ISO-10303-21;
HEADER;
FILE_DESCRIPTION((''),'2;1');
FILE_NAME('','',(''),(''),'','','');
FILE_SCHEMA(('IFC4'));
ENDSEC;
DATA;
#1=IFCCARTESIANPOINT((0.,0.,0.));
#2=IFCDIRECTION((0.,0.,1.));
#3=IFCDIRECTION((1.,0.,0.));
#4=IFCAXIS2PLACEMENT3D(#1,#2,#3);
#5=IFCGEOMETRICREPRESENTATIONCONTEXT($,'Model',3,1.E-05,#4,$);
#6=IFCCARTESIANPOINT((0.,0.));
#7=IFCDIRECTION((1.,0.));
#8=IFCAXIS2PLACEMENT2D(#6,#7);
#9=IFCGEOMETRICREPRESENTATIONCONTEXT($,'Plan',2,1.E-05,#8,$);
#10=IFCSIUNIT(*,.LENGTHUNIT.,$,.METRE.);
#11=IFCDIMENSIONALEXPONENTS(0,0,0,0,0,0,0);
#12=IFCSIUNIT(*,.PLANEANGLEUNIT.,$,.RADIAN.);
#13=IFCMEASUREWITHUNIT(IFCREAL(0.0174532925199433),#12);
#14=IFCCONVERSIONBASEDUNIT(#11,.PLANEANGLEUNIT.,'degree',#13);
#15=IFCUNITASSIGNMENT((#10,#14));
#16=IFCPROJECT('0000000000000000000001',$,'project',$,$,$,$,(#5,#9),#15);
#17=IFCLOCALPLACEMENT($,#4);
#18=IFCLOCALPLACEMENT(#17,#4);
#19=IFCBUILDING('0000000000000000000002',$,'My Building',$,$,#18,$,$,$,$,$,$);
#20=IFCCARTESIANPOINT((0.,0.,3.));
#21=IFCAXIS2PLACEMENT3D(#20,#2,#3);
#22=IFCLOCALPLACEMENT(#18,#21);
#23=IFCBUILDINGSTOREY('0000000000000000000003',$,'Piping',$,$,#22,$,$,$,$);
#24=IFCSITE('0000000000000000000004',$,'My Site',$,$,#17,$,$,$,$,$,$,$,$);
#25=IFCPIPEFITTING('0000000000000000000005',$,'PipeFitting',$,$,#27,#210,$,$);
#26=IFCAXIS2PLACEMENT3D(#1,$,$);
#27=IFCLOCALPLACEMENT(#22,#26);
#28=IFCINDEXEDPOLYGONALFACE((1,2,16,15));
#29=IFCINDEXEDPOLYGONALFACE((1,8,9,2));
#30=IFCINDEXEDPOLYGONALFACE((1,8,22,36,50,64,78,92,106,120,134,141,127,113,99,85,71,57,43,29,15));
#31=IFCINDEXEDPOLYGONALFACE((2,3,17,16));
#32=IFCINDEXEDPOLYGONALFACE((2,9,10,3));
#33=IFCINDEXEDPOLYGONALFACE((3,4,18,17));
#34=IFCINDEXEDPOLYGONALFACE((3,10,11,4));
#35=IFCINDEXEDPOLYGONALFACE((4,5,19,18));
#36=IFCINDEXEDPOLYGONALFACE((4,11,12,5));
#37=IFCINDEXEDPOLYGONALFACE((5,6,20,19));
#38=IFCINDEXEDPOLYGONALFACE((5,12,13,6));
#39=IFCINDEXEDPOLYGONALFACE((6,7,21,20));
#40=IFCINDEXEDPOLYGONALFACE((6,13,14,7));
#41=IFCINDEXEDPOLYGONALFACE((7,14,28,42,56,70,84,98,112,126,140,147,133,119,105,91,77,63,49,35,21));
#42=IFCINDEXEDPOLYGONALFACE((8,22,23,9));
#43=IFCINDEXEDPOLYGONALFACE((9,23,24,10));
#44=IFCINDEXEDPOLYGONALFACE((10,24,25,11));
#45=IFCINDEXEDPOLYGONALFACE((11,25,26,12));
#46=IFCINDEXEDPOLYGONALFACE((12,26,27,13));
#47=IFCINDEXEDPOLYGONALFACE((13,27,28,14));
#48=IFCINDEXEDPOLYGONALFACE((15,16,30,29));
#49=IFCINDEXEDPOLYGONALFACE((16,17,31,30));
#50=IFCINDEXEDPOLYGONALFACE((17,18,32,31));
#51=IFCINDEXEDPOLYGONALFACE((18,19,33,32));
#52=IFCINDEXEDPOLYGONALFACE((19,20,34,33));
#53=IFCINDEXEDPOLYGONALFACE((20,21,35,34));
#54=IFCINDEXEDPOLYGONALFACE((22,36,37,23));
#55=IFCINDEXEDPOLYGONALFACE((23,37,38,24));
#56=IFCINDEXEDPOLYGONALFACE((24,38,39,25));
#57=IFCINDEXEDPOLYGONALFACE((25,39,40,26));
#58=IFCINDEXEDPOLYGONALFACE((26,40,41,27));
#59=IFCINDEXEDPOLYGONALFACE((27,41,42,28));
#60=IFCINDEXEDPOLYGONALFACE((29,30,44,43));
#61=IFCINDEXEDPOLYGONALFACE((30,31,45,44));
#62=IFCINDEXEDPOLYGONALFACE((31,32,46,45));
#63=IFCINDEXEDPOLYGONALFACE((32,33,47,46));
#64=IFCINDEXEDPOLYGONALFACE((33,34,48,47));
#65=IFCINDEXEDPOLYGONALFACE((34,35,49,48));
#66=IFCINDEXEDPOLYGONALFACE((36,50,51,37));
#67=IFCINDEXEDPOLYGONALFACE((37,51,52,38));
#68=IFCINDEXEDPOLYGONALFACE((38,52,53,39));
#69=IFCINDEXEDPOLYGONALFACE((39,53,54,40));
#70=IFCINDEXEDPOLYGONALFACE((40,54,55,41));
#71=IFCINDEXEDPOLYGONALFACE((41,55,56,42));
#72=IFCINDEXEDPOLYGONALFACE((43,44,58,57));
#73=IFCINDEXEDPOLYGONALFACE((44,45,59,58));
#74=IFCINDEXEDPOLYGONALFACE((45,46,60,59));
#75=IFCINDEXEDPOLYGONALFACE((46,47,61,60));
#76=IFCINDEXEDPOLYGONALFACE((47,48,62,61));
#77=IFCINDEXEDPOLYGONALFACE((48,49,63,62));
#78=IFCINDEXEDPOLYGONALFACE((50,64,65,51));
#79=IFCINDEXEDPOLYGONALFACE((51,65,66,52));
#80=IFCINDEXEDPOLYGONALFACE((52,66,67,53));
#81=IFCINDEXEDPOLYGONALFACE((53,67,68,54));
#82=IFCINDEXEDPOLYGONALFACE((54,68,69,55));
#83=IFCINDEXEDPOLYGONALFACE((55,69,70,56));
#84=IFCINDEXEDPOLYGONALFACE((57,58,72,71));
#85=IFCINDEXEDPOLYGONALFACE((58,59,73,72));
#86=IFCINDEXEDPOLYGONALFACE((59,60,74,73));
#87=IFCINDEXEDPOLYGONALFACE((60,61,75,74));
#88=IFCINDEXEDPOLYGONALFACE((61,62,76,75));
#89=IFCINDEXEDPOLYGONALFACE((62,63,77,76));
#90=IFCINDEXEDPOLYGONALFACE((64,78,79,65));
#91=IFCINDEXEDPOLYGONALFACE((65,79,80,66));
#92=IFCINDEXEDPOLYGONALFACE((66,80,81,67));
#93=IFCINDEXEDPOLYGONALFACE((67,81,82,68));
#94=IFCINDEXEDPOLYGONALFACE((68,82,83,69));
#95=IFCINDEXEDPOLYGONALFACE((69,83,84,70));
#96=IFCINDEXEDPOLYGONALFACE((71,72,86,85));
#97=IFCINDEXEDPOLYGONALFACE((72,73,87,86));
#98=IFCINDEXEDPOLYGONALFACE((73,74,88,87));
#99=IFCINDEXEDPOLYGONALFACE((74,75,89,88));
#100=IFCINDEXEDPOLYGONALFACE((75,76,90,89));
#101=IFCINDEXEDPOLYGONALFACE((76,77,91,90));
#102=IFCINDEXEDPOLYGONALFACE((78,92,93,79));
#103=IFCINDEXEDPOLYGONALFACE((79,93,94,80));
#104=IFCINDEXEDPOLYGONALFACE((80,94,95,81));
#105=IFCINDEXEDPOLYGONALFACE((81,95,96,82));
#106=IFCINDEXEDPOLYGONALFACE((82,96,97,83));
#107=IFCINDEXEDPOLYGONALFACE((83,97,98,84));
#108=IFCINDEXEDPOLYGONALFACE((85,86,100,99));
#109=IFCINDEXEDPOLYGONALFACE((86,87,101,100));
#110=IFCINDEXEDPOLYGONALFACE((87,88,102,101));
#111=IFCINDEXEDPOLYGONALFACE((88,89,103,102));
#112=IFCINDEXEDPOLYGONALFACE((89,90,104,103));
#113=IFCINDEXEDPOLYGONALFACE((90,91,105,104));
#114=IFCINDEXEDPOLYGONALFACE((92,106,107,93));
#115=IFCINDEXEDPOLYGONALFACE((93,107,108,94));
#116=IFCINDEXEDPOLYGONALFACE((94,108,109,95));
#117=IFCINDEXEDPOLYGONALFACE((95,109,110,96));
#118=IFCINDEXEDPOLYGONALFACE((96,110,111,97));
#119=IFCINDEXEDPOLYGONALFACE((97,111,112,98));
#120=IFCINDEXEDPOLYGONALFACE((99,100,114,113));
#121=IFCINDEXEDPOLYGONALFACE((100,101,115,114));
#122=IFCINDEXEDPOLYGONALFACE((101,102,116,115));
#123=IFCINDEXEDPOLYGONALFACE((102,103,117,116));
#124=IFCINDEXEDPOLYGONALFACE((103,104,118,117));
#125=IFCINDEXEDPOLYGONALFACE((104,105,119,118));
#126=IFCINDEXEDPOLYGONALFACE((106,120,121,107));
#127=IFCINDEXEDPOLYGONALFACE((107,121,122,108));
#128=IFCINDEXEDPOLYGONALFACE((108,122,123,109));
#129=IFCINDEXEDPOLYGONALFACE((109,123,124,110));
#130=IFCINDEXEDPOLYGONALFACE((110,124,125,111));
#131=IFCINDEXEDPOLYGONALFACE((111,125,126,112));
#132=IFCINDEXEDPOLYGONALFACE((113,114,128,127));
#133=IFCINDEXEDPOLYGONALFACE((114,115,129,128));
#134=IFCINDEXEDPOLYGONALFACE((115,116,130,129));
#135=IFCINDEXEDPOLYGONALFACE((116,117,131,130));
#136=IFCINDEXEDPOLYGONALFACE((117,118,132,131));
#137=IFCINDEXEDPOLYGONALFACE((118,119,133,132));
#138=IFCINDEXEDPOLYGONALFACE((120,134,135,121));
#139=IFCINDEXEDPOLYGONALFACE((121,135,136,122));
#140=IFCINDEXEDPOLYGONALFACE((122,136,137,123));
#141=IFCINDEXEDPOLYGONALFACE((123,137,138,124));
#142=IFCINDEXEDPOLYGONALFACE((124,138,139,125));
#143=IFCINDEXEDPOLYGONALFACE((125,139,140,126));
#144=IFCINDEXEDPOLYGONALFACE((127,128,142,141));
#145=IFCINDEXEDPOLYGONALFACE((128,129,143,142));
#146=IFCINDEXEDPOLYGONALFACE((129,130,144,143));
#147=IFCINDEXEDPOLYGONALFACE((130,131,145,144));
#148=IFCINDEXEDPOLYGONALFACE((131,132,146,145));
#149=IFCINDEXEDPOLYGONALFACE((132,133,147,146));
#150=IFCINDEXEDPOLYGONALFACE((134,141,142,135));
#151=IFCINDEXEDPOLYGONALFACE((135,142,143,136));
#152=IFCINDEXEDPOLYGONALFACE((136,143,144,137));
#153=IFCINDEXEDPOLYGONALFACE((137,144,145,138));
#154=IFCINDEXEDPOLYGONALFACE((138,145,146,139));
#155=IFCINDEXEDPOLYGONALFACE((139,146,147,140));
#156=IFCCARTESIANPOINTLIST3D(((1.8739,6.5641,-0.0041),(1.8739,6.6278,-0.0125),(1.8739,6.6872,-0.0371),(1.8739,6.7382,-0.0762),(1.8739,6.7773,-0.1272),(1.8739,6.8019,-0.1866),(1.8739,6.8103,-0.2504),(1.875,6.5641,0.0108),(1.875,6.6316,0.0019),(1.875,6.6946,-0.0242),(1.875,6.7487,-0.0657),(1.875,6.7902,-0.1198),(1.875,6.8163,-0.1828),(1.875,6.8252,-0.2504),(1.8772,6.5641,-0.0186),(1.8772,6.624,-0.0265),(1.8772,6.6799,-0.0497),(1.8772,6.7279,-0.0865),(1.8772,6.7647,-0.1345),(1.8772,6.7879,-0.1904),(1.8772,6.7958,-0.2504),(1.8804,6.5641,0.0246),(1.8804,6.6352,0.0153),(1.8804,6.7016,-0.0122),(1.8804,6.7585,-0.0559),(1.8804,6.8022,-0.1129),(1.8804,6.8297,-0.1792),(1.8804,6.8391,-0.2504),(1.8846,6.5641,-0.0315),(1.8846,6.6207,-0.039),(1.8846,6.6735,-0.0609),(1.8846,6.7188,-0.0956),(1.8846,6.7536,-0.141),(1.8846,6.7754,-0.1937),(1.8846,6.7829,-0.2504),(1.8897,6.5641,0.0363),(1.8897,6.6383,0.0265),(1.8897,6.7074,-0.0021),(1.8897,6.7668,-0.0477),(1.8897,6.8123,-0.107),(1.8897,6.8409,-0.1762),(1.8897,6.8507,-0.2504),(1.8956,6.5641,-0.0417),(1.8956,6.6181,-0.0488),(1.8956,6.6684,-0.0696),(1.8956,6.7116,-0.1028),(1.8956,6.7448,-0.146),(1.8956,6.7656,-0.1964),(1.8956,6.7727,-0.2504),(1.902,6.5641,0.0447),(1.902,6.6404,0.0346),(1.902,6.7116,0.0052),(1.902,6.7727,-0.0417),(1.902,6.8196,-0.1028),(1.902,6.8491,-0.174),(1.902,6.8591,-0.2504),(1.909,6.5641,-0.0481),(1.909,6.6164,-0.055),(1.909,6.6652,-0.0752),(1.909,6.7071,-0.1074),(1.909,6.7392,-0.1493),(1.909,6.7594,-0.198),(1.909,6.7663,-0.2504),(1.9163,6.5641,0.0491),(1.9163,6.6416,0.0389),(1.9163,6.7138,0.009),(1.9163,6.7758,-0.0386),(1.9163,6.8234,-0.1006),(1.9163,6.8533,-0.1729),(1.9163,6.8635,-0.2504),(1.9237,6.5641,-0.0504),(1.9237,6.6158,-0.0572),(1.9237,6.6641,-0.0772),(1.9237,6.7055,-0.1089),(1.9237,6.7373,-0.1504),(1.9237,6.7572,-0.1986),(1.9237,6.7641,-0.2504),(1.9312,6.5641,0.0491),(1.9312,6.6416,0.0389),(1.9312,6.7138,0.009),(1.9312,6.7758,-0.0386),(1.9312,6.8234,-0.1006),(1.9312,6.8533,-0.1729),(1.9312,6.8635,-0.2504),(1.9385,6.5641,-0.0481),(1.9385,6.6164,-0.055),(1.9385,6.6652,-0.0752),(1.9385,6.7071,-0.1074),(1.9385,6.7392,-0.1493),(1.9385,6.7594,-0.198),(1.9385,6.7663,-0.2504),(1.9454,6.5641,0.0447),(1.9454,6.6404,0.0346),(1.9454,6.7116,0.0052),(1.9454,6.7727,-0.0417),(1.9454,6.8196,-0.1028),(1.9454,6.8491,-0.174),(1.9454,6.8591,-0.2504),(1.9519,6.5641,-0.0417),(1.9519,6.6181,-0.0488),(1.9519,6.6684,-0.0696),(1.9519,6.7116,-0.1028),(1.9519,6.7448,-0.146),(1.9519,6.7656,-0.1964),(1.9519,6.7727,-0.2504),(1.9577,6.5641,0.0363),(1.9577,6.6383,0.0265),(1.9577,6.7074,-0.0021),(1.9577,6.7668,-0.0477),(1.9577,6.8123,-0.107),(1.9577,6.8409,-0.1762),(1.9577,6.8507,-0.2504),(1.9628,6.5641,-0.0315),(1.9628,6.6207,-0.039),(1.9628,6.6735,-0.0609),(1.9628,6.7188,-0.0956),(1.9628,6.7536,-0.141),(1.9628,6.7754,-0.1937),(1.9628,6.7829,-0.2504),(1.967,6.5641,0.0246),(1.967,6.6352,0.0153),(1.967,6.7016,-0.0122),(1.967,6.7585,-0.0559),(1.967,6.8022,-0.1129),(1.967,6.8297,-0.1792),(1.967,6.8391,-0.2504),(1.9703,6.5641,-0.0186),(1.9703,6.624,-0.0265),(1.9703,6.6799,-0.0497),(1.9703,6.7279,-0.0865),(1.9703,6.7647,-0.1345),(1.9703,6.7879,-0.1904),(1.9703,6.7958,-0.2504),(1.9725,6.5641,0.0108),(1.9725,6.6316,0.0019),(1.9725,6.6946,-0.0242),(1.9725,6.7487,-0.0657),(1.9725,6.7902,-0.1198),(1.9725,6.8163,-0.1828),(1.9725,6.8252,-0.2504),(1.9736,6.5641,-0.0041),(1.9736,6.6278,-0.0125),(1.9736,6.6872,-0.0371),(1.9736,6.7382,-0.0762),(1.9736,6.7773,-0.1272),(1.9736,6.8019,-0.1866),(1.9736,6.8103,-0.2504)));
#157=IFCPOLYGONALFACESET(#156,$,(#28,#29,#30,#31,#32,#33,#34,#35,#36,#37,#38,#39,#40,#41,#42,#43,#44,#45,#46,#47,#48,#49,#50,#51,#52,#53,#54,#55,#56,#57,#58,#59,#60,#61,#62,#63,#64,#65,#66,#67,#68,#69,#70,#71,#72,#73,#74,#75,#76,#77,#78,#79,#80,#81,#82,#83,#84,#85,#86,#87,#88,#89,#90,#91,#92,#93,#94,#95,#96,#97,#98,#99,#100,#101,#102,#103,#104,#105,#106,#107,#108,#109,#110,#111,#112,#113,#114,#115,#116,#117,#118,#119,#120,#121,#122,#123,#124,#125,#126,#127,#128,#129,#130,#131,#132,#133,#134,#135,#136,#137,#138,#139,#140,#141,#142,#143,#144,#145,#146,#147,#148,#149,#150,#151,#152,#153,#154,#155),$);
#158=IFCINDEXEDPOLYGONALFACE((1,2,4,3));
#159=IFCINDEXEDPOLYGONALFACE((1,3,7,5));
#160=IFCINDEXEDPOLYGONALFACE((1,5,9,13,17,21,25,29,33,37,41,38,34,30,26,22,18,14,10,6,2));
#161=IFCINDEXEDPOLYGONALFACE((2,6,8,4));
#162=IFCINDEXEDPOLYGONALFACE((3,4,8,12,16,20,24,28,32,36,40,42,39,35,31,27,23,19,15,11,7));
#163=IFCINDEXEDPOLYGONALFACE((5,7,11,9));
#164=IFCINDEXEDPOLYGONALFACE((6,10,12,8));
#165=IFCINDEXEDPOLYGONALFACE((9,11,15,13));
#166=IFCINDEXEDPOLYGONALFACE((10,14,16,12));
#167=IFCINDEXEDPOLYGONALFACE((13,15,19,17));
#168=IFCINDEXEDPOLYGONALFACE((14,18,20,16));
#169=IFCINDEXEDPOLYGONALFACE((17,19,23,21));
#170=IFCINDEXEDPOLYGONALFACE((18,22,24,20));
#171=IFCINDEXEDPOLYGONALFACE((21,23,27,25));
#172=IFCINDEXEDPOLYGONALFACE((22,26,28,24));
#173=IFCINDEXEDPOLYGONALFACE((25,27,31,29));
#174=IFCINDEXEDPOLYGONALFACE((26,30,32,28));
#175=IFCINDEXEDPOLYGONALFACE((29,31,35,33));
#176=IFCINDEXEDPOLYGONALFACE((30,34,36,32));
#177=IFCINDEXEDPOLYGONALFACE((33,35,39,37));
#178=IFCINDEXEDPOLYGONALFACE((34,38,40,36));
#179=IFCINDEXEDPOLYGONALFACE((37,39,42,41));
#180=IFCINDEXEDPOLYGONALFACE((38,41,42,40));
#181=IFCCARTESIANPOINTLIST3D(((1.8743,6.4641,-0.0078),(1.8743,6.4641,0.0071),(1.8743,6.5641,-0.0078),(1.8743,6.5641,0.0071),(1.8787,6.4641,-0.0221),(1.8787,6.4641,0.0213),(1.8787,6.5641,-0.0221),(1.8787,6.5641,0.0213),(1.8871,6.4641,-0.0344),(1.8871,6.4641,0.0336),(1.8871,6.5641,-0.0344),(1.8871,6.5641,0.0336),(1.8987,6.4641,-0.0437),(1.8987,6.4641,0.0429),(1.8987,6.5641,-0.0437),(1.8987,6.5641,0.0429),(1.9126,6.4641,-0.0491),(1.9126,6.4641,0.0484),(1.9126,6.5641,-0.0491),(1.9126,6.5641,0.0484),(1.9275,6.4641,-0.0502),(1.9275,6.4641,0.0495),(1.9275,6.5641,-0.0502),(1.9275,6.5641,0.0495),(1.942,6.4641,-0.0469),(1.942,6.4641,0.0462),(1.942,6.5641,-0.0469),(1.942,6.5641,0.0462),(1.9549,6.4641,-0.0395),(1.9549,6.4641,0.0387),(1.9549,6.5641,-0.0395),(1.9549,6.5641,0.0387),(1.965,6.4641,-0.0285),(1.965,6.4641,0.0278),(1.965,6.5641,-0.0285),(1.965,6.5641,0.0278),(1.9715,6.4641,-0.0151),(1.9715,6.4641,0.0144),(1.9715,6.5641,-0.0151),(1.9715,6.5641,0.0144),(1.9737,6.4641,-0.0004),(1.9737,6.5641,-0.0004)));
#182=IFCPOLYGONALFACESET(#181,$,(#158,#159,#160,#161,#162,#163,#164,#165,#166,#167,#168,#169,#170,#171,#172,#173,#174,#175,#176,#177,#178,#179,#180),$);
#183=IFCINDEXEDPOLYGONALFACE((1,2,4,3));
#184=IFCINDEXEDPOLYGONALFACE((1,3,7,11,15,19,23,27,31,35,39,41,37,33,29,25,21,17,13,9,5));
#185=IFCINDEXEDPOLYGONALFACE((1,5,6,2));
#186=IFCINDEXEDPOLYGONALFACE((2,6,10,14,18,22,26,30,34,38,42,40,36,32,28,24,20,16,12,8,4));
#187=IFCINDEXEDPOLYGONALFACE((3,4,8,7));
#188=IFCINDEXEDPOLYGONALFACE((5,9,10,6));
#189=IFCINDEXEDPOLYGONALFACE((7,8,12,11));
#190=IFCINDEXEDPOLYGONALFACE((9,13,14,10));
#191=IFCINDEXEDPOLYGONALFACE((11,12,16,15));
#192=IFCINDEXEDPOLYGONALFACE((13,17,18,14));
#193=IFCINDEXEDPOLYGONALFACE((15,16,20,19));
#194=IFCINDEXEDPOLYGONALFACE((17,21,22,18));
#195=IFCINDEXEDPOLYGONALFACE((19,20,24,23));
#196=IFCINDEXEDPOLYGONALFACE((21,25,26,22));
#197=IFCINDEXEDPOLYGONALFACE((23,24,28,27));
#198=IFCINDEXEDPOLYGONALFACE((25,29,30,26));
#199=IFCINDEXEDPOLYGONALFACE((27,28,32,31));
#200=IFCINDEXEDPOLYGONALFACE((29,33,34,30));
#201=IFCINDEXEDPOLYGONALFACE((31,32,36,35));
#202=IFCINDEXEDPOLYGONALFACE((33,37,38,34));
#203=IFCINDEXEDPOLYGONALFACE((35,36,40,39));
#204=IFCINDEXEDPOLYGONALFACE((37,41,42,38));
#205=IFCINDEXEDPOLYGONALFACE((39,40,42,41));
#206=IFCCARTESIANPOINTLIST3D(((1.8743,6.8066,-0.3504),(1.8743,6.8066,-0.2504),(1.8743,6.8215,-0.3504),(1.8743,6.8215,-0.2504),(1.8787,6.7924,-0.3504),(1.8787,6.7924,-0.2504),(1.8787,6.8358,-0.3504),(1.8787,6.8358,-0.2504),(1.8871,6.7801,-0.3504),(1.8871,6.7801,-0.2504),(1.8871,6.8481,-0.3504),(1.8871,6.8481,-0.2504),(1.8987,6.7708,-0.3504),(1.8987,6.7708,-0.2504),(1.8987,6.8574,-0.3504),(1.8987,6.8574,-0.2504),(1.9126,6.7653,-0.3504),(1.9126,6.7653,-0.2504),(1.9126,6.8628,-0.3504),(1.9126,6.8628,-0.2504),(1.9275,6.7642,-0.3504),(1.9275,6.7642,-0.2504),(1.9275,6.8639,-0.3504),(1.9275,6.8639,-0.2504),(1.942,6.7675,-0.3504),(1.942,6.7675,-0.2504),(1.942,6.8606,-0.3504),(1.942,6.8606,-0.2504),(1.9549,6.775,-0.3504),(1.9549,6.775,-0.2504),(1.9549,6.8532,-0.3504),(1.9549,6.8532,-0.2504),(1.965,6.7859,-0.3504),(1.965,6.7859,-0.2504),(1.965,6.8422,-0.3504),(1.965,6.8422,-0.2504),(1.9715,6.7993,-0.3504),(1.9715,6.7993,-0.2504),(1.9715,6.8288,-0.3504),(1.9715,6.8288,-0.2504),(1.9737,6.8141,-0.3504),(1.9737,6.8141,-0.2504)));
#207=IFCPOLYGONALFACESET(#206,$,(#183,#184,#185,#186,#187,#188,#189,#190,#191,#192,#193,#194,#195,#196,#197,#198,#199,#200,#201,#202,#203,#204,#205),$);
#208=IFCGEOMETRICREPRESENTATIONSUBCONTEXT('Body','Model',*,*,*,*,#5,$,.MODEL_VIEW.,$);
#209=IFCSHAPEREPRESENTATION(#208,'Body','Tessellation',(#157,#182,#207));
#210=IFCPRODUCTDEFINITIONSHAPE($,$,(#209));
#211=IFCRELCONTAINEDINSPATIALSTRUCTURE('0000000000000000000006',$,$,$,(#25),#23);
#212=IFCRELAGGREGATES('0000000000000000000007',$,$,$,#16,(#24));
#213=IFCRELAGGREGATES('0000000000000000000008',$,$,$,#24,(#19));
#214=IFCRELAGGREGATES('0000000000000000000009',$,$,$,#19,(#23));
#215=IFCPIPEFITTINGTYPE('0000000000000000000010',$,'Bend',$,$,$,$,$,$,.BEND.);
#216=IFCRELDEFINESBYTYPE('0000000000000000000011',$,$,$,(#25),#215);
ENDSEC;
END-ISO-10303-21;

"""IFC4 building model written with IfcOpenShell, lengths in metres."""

from ifc_helpers import new_model, entity, si_unit, converted_unit, frame, origin_with_axes, origin_2d_with_axis, place, context, subcontext, project, spatial, circle, extrude, source, transform, mapped, type_object, type_shapes, element, save


model = new_model("IFC4")

# Units and contexts
model_context = context("Model", 3, precision=1e-05, world=origin_with_axes())
plan_context = context("Plan", 2, precision=1e-05, world=origin_2d_with_axis())
body_context = subcontext(model_context, "Body", "Model", "MODEL_VIEW")
ifc_project = project(units=[si_unit("LENGTHUNIT", "METRE"), converted_unit("PLANEANGLEUNIT", "degree", entity("IfcReal", 0.0174532925199433), si_unit("PLANEANGLEUNIT", "RADIAN"), dimensions=[0, 0, 0, 0, 0, 0, 0])], contexts=[model_context, plan_context])

# Site, building, storey
site_placement = place(None, origin_with_axes())
site = spatial("IfcSite", under=ifc_project, at=site_placement, Name="My Site")
building_placement = place(site_placement, origin_with_axes())
building = spatial("IfcBuilding", under=site, at=building_placement, Name="My Building")
storey_placement = place(building_placement, frame((0.0, 0.0, 3.0), z_axis=(0.0, 0.0, 1.0), x_axis=(1.0, 0.0, 0.0)))
storey = spatial("IfcBuildingStorey", under=building, at=storey_placement, Name="Piping")

# Shared definitions
pipe_fitting_type = type_object("IfcPipeFittingType", Name="Bend", PredefinedType="BEND")
shared_shape = source(origin_with_axes(), body_context, "Body", "SolidModel", [
    entity("IfcSweptDiskSolid", entity("IfcIndexedPolyCurve", entity("IfcCartesianPointList3D", [[0.0, 0.0, -0.1], [0.0, -0.0732, -0.2768], [0.0, -0.25, -0.35]]), [entity("IfcArcIndex", [1, 2, 3])]), 0.05),
    extrude(circle(Radius=0.05), origin_with_axes(), (0.0, 0.0, -1.0), 0.1),
    extrude(circle(Radius=0.05), frame((0.0, -0.25, -0.35), z_axis=(0.0, -1.0, 0.0), x_axis=(1.0, 0.0, 0.0)), (0.0, 0.0, 1.0), 0.1),
])
type_shapes(pipe_fitting_type, [shared_shape])

# Pipe fitting
for number, where, z_axis, x_axis, name in (
    (1, (1.9237, 6.4641, -0.0004), (0.0, -1.0, 0.0), (1.0, 0.0, 0.0), "PipeFitting"),
):
    element("IfcPipeFitting", number, at=place(storey_placement, frame(where, z_axis=z_axis, x_axis=x_axis)), inside=storey, type_object=pipe_fitting_type, Name=name, context=body_context, shape_type="MappedRepresentation", body=[
        mapped(shared_shape, transform((0.0, 0.0, 0.0), x_axis=(1.0, 0.0, 0.0), y_axis=(0.0, 1.0, 0.0), z_axis=(0.0, 0.0, 1.0), scale=1.0)),
    ])

save(model, "model.ifc")
